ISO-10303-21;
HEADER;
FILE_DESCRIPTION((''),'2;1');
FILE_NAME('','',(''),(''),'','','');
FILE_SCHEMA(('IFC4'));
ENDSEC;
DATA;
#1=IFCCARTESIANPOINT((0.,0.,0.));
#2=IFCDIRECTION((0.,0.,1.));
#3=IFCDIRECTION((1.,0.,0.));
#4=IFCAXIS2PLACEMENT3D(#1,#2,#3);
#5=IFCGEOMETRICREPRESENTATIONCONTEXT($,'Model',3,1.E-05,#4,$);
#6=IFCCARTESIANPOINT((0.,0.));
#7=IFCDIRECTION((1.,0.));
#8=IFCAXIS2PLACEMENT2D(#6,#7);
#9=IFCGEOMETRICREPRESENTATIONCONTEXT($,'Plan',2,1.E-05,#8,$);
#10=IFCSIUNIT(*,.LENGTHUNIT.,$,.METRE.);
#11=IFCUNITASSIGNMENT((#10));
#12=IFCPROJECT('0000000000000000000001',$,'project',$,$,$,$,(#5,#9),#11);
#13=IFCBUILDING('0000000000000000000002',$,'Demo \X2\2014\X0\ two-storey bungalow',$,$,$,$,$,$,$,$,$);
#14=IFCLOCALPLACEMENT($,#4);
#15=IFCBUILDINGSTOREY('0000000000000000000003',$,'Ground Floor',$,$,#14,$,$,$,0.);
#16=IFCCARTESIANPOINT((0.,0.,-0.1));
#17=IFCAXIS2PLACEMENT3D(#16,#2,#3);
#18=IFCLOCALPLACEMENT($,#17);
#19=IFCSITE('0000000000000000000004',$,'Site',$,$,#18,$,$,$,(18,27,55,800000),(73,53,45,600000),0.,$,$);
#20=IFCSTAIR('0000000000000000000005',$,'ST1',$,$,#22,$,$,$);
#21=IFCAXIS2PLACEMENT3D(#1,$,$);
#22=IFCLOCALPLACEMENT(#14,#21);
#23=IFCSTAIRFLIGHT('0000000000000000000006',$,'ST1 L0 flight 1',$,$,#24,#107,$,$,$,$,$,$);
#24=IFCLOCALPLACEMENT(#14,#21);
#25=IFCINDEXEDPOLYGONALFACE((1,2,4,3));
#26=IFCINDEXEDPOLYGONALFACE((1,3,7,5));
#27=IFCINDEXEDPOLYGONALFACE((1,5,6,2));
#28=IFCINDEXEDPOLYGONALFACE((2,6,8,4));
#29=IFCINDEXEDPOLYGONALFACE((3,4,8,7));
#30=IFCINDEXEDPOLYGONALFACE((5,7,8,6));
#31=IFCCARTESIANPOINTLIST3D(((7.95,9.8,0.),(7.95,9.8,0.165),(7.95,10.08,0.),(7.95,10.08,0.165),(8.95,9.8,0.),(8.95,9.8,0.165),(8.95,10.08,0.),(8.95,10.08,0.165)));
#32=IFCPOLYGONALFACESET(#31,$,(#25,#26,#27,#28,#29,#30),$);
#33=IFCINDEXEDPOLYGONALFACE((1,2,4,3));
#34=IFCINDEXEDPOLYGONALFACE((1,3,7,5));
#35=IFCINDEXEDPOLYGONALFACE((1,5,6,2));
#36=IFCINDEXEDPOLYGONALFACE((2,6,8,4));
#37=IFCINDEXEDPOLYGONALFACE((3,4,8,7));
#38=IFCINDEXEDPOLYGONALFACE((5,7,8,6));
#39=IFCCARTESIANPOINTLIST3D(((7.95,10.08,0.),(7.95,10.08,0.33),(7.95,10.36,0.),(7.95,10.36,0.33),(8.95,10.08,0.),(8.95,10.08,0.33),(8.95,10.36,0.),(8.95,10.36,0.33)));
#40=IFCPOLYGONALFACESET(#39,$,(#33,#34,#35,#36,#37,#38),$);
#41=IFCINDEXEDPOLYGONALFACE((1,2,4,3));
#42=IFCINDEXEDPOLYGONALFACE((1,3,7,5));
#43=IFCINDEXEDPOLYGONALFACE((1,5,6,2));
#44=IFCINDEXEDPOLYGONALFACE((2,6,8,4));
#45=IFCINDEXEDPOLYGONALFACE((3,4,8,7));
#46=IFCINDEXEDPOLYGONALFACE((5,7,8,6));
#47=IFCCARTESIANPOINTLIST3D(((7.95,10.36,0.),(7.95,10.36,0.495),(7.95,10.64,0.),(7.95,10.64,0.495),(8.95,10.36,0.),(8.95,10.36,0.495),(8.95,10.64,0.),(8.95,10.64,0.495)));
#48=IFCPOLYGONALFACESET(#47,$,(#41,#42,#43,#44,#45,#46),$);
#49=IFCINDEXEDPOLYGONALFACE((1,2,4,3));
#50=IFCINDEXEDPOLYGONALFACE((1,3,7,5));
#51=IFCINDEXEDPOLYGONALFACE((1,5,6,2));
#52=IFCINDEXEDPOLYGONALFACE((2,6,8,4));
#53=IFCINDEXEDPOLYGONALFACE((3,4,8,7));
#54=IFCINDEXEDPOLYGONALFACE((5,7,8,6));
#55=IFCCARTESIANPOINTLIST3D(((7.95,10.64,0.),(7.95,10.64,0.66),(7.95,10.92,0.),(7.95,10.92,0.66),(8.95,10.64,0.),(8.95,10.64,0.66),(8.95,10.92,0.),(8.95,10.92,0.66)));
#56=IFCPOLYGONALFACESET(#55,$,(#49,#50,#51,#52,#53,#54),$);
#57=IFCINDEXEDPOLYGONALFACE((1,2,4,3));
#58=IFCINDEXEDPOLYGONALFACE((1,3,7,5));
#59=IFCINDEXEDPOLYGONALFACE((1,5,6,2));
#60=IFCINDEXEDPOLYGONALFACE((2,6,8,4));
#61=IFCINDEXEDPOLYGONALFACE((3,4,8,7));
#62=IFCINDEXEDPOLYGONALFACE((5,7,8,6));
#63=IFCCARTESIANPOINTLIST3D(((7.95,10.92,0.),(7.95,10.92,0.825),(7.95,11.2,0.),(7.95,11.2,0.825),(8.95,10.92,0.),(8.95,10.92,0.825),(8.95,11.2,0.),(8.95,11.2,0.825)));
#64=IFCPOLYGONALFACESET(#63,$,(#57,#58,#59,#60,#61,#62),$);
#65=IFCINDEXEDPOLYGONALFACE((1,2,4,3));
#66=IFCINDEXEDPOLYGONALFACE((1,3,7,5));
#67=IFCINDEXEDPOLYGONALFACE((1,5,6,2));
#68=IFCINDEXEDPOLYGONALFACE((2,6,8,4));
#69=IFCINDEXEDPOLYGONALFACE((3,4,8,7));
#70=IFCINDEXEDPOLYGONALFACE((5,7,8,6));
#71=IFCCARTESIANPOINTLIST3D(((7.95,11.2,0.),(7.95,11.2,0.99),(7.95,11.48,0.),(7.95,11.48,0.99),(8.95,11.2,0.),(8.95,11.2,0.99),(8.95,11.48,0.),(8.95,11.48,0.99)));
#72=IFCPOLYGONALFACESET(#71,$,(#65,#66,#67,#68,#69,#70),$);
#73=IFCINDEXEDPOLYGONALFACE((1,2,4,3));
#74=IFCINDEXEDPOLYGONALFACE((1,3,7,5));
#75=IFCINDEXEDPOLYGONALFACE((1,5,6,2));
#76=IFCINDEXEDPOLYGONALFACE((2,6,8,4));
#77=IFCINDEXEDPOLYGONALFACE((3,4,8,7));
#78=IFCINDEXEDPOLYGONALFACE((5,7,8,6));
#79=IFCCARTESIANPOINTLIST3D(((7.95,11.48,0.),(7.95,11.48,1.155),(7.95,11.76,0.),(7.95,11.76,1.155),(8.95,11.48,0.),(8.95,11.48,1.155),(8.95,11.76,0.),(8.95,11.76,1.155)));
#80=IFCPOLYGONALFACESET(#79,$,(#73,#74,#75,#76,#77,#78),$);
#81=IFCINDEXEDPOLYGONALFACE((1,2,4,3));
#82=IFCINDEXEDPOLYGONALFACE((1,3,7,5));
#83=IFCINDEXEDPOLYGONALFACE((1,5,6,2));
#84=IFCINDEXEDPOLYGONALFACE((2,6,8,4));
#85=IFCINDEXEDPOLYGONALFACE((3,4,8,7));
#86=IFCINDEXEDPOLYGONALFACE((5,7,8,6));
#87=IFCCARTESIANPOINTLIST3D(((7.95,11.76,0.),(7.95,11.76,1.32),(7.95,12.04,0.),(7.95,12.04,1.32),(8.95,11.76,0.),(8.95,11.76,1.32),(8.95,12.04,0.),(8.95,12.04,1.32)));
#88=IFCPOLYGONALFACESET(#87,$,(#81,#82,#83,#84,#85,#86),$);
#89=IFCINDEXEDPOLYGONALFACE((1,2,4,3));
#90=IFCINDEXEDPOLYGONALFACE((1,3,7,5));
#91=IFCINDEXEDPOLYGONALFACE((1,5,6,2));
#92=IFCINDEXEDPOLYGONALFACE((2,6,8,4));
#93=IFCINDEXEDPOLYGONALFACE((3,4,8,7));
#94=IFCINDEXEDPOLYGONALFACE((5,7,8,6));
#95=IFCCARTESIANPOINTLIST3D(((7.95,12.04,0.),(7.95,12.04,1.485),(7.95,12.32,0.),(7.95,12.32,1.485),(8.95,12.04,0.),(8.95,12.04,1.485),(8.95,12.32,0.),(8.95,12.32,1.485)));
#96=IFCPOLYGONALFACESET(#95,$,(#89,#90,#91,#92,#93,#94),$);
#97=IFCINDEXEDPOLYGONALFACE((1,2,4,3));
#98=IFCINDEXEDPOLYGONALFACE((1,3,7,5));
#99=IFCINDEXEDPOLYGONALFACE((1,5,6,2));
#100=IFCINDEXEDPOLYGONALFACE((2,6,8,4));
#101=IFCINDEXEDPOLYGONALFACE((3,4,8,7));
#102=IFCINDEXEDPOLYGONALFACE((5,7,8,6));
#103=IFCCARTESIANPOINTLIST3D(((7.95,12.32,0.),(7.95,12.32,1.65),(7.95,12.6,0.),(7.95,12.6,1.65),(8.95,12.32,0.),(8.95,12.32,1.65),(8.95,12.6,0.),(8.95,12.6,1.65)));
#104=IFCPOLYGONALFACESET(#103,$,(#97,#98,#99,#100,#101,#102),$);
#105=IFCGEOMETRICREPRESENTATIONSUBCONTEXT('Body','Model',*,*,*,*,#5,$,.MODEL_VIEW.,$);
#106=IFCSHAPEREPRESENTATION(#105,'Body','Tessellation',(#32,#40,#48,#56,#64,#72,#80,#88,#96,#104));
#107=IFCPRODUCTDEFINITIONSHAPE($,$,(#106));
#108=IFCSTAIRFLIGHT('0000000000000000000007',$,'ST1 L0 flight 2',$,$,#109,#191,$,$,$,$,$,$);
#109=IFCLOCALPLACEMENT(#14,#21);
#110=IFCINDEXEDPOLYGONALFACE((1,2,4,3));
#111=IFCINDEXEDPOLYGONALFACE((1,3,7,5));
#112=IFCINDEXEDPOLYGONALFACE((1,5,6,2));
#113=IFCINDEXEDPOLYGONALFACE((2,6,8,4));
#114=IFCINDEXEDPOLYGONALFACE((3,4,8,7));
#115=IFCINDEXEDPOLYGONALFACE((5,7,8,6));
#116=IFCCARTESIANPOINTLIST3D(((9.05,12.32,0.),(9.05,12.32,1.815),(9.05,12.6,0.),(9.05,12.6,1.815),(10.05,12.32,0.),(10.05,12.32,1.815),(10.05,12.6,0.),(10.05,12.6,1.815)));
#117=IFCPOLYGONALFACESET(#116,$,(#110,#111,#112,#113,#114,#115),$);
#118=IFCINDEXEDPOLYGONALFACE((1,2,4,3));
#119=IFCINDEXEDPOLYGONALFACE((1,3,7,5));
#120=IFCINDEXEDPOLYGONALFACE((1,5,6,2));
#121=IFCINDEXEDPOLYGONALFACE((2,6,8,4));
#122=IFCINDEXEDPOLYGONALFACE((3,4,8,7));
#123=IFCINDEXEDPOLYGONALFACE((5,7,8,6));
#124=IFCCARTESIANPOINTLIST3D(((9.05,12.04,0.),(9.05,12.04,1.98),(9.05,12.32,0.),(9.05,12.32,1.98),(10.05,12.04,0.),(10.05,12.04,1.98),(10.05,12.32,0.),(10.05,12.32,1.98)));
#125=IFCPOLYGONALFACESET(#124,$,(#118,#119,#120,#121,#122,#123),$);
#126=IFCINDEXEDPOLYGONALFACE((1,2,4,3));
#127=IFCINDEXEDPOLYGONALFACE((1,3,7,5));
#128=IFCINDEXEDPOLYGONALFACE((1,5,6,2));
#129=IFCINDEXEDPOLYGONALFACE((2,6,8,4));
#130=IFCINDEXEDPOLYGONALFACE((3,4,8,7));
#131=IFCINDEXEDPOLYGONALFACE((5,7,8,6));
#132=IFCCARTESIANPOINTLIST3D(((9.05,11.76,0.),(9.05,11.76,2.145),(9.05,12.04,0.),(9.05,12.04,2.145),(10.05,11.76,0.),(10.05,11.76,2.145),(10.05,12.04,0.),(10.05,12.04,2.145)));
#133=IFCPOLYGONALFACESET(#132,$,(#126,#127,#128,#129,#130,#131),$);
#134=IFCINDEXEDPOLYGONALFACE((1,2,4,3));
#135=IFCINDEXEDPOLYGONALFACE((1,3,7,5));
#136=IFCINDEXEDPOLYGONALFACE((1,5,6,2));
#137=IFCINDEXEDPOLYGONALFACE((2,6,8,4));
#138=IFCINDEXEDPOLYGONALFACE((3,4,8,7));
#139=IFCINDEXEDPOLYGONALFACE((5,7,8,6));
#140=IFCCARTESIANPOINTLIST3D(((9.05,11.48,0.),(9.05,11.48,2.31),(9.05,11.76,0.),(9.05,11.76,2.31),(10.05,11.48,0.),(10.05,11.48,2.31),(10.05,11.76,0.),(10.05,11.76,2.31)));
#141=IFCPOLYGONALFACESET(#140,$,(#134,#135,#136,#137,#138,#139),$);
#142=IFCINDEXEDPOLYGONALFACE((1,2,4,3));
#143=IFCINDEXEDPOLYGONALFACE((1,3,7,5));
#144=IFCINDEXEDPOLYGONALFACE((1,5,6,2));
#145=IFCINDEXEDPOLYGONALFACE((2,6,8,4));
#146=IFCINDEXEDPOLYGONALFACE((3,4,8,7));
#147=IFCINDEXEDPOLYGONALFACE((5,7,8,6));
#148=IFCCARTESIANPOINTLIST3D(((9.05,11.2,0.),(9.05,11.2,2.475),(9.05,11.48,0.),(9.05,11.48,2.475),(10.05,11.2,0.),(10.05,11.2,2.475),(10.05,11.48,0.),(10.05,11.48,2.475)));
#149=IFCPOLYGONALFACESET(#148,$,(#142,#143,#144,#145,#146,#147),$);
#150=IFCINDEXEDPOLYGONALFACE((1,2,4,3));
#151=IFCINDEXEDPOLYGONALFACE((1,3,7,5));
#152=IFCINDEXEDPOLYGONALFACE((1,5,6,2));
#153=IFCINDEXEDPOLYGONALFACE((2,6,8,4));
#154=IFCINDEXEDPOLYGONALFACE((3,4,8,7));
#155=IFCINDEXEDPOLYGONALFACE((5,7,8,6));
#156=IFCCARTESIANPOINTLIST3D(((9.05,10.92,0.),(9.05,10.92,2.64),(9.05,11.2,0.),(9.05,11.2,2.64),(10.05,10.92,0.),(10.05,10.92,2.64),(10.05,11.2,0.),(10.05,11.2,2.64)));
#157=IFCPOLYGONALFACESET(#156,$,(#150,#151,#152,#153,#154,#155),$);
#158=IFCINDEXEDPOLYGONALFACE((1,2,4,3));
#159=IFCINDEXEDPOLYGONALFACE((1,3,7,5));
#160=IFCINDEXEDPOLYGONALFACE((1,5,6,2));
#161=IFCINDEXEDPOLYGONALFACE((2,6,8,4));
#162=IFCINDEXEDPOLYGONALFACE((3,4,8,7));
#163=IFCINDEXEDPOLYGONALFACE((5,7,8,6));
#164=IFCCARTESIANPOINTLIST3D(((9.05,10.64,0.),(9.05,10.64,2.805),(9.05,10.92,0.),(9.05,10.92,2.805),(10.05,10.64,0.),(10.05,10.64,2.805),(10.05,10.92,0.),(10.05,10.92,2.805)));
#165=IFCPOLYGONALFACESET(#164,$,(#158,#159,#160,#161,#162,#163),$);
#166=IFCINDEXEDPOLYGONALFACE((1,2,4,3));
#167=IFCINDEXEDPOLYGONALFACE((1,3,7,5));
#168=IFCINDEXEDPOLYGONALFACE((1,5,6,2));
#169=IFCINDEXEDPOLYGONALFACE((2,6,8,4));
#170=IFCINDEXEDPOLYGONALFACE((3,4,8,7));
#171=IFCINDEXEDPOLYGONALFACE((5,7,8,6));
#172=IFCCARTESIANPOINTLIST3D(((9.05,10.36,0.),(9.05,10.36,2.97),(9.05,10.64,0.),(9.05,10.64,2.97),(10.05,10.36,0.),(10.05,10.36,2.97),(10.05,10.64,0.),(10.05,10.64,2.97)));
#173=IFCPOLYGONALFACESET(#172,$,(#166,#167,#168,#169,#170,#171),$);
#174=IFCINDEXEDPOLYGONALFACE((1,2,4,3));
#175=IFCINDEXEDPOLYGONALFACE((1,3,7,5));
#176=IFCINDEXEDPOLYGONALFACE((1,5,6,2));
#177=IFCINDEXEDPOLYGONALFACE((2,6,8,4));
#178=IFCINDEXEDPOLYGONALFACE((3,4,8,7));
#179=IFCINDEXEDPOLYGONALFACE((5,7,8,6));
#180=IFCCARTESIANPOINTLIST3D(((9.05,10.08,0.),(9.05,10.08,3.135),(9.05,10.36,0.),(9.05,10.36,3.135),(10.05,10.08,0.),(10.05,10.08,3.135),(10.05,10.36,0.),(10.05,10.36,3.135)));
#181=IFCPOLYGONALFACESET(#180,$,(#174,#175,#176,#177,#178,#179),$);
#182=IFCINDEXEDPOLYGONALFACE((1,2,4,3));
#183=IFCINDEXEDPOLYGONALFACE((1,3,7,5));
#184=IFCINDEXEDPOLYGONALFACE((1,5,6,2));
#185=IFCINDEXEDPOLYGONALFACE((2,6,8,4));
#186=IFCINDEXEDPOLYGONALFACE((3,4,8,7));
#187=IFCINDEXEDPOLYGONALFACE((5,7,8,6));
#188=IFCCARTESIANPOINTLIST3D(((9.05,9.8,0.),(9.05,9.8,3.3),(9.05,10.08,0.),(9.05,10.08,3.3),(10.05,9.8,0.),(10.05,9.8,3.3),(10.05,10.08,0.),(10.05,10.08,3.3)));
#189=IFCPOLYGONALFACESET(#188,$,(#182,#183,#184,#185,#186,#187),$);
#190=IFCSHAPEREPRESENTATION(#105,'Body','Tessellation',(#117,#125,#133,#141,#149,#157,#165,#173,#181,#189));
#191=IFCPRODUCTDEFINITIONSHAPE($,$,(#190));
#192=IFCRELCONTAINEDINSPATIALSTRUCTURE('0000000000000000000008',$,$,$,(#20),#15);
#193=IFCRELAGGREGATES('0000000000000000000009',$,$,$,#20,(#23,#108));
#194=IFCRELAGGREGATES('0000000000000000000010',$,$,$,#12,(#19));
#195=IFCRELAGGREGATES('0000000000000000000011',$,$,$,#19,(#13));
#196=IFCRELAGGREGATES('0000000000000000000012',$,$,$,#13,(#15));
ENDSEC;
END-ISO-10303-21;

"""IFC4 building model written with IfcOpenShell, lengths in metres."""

from ifc_helpers import new_model, si_unit, frame, origin_with_axes, origin_2d_with_axis, place, context, subcontext, project, spatial, line, indexed_curve, outline, extrude, element, aggregate, save


model = new_model("IFC4")

# Units and contexts
model_context = context("Model", 3, precision=1e-05, world=origin_with_axes())
plan_context = context("Plan", 2, precision=1e-05, world=origin_2d_with_axis())
body_context = subcontext(model_context, "Body", "Model", "MODEL_VIEW")
ifc_project = project(units=[si_unit("LENGTHUNIT", "METRE")], contexts=[model_context, plan_context])

# Site, building, storey
site_placement = place(None, frame((0.0, 0.0, -0.1), z_axis=(0.0, 0.0, 1.0), x_axis=(1.0, 0.0, 0.0)))
site = spatial("IfcSite", under=ifc_project, at=site_placement, Name="Site", RefLatitude=(18, 27, 55, 800000), RefLongitude=(73, 53, 45, 600000), RefElevation=0.0)
building = spatial("IfcBuilding", under=site, Name="Demo — two-storey bungalow")
storey_placement = place(None, origin_with_axes())
storey = spatial("IfcBuildingStorey", under=building, at=storey_placement, Name="Ground Floor", Elevation=0.0)

# Stair, stair flights
stair = element("IfcStair", 1, inside=storey, Name="ST1")
stair_flight_1_placement = place(None, origin_with_axes())
stair_flight_1 = element("IfcStairFlight", 2, at=stair_flight_1_placement, Name="ST1 L0 flight 1", context=body_context, shape_type="SweptSolid", body=[
    extrude(outline(indexed_curve([(7.95, 9.8), (8.95, 9.8), (8.95, 10.08), (7.95, 10.08)], segments=[line(1, 2, 3, 4, 1)])), origin_with_axes(), (0.0, 0.0, 1.0), 0.165),
    extrude(outline(indexed_curve([(7.95, 10.08), (8.95, 10.08), (8.95, 10.36), (7.95, 10.36)], segments=[line(1, 2, 3, 4, 1)])), origin_with_axes(), (0.0, 0.0, 1.0), 0.33),
    extrude(outline(indexed_curve([(7.95, 10.36), (8.95, 10.36), (8.95, 10.64), (7.95, 10.64)], segments=[line(1, 2, 3, 4, 1)])), origin_with_axes(), (0.0, 0.0, 1.0), 0.495),
    extrude(outline(indexed_curve([(7.95, 10.64), (8.95, 10.64), (8.95, 10.92), (7.95, 10.92)], segments=[line(1, 2, 3, 4, 1)])), origin_with_axes(), (0.0, 0.0, 1.0), 0.66),
    extrude(outline(indexed_curve([(7.95, 10.92), (8.95, 10.92), (8.95, 11.2), (7.95, 11.2)], segments=[line(1, 2, 3, 4, 1)])), origin_with_axes(), (0.0, 0.0, 1.0), 0.825),
    extrude(outline(indexed_curve([(7.95, 11.2), (8.95, 11.2), (8.95, 11.48), (7.95, 11.48)], segments=[line(1, 2, 3, 4, 1)])), origin_with_axes(), (0.0, 0.0, 1.0), 0.99),
    extrude(outline(indexed_curve([(7.95, 11.48), (8.95, 11.48), (8.95, 11.76), (7.95, 11.76)], segments=[line(1, 2, 3, 4, 1)])), origin_with_axes(), (0.0, 0.0, 1.0), 1.155),
    extrude(outline(indexed_curve([(7.95, 11.76), (8.95, 11.76), (8.95, 12.04), (7.95, 12.04)], segments=[line(1, 2, 3, 4, 1)])), origin_with_axes(), (0.0, 0.0, 1.0), 1.32),
    extrude(outline(indexed_curve([(7.95, 12.04), (8.95, 12.04), (8.95, 12.32), (7.95, 12.32)], segments=[line(1, 2, 3, 4, 1)])), origin_with_axes(), (0.0, 0.0, 1.0), 1.485),
    extrude(outline(indexed_curve([(7.95, 12.32), (8.95, 12.32), (8.95, 12.6), (7.95, 12.6)], segments=[line(1, 2, 3, 4, 1)])), origin_with_axes(), (0.0, 0.0, 1.0), 1.65),
])
stair_flight_2_placement = place(None, origin_with_axes())
stair_flight_2 = element("IfcStairFlight", 3, at=stair_flight_2_placement, Name="ST1 L0 flight 2", context=body_context, shape_type="SweptSolid", body=[
    extrude(outline(indexed_curve([(9.05, 12.32), (10.05, 12.32), (10.05, 12.6), (9.05, 12.6)], segments=[line(1, 2, 3, 4, 1)])), origin_with_axes(), (0.0, 0.0, 1.0), 1.815),
    extrude(outline(indexed_curve([(9.05, 12.04), (10.05, 12.04), (10.05, 12.32), (9.05, 12.32)], segments=[line(1, 2, 3, 4, 1)])), origin_with_axes(), (0.0, 0.0, 1.0), 1.98),
    extrude(outline(indexed_curve([(9.05, 11.76), (10.05, 11.76), (10.05, 12.04), (9.05, 12.04)], segments=[line(1, 2, 3, 4, 1)])), origin_with_axes(), (0.0, 0.0, 1.0), 2.145),
    extrude(outline(indexed_curve([(9.05, 11.48), (10.05, 11.48), (10.05, 11.76), (9.05, 11.76)], segments=[line(1, 2, 3, 4, 1)])), origin_with_axes(), (0.0, 0.0, 1.0), 2.31),
    extrude(outline(indexed_curve([(9.05, 11.2), (10.05, 11.2), (10.05, 11.48), (9.05, 11.48)], segments=[line(1, 2, 3, 4, 1)])), origin_with_axes(), (0.0, 0.0, 1.0), 2.475),
    extrude(outline(indexed_curve([(9.05, 10.92), (10.05, 10.92), (10.05, 11.2), (9.05, 11.2)], segments=[line(1, 2, 3, 4, 1)])), origin_with_axes(), (0.0, 0.0, 1.0), 2.64),
    extrude(outline(indexed_curve([(9.05, 10.64), (10.05, 10.64), (10.05, 10.92), (9.05, 10.92)], segments=[line(1, 2, 3, 4, 1)])), origin_with_axes(), (0.0, 0.0, 1.0), 2.805),
    extrude(outline(indexed_curve([(9.05, 10.36), (10.05, 10.36), (10.05, 10.64), (9.05, 10.64)], segments=[line(1, 2, 3, 4, 1)])), origin_with_axes(), (0.0, 0.0, 1.0), 2.97),
    extrude(outline(indexed_curve([(9.05, 10.08), (10.05, 10.08), (10.05, 10.36), (9.05, 10.36)], segments=[line(1, 2, 3, 4, 1)])), origin_with_axes(), (0.0, 0.0, 1.0), 3.135),
    extrude(outline(indexed_curve([(9.05, 9.8), (10.05, 9.8), (10.05, 10.08), (9.05, 10.08)], segments=[line(1, 2, 3, 4, 1)])), origin_with_axes(), (0.0, 0.0, 1.0), 3.3),
])
aggregate(stair, [stair_flight_1, stair_flight_2])

save(model, "model.ifc")
